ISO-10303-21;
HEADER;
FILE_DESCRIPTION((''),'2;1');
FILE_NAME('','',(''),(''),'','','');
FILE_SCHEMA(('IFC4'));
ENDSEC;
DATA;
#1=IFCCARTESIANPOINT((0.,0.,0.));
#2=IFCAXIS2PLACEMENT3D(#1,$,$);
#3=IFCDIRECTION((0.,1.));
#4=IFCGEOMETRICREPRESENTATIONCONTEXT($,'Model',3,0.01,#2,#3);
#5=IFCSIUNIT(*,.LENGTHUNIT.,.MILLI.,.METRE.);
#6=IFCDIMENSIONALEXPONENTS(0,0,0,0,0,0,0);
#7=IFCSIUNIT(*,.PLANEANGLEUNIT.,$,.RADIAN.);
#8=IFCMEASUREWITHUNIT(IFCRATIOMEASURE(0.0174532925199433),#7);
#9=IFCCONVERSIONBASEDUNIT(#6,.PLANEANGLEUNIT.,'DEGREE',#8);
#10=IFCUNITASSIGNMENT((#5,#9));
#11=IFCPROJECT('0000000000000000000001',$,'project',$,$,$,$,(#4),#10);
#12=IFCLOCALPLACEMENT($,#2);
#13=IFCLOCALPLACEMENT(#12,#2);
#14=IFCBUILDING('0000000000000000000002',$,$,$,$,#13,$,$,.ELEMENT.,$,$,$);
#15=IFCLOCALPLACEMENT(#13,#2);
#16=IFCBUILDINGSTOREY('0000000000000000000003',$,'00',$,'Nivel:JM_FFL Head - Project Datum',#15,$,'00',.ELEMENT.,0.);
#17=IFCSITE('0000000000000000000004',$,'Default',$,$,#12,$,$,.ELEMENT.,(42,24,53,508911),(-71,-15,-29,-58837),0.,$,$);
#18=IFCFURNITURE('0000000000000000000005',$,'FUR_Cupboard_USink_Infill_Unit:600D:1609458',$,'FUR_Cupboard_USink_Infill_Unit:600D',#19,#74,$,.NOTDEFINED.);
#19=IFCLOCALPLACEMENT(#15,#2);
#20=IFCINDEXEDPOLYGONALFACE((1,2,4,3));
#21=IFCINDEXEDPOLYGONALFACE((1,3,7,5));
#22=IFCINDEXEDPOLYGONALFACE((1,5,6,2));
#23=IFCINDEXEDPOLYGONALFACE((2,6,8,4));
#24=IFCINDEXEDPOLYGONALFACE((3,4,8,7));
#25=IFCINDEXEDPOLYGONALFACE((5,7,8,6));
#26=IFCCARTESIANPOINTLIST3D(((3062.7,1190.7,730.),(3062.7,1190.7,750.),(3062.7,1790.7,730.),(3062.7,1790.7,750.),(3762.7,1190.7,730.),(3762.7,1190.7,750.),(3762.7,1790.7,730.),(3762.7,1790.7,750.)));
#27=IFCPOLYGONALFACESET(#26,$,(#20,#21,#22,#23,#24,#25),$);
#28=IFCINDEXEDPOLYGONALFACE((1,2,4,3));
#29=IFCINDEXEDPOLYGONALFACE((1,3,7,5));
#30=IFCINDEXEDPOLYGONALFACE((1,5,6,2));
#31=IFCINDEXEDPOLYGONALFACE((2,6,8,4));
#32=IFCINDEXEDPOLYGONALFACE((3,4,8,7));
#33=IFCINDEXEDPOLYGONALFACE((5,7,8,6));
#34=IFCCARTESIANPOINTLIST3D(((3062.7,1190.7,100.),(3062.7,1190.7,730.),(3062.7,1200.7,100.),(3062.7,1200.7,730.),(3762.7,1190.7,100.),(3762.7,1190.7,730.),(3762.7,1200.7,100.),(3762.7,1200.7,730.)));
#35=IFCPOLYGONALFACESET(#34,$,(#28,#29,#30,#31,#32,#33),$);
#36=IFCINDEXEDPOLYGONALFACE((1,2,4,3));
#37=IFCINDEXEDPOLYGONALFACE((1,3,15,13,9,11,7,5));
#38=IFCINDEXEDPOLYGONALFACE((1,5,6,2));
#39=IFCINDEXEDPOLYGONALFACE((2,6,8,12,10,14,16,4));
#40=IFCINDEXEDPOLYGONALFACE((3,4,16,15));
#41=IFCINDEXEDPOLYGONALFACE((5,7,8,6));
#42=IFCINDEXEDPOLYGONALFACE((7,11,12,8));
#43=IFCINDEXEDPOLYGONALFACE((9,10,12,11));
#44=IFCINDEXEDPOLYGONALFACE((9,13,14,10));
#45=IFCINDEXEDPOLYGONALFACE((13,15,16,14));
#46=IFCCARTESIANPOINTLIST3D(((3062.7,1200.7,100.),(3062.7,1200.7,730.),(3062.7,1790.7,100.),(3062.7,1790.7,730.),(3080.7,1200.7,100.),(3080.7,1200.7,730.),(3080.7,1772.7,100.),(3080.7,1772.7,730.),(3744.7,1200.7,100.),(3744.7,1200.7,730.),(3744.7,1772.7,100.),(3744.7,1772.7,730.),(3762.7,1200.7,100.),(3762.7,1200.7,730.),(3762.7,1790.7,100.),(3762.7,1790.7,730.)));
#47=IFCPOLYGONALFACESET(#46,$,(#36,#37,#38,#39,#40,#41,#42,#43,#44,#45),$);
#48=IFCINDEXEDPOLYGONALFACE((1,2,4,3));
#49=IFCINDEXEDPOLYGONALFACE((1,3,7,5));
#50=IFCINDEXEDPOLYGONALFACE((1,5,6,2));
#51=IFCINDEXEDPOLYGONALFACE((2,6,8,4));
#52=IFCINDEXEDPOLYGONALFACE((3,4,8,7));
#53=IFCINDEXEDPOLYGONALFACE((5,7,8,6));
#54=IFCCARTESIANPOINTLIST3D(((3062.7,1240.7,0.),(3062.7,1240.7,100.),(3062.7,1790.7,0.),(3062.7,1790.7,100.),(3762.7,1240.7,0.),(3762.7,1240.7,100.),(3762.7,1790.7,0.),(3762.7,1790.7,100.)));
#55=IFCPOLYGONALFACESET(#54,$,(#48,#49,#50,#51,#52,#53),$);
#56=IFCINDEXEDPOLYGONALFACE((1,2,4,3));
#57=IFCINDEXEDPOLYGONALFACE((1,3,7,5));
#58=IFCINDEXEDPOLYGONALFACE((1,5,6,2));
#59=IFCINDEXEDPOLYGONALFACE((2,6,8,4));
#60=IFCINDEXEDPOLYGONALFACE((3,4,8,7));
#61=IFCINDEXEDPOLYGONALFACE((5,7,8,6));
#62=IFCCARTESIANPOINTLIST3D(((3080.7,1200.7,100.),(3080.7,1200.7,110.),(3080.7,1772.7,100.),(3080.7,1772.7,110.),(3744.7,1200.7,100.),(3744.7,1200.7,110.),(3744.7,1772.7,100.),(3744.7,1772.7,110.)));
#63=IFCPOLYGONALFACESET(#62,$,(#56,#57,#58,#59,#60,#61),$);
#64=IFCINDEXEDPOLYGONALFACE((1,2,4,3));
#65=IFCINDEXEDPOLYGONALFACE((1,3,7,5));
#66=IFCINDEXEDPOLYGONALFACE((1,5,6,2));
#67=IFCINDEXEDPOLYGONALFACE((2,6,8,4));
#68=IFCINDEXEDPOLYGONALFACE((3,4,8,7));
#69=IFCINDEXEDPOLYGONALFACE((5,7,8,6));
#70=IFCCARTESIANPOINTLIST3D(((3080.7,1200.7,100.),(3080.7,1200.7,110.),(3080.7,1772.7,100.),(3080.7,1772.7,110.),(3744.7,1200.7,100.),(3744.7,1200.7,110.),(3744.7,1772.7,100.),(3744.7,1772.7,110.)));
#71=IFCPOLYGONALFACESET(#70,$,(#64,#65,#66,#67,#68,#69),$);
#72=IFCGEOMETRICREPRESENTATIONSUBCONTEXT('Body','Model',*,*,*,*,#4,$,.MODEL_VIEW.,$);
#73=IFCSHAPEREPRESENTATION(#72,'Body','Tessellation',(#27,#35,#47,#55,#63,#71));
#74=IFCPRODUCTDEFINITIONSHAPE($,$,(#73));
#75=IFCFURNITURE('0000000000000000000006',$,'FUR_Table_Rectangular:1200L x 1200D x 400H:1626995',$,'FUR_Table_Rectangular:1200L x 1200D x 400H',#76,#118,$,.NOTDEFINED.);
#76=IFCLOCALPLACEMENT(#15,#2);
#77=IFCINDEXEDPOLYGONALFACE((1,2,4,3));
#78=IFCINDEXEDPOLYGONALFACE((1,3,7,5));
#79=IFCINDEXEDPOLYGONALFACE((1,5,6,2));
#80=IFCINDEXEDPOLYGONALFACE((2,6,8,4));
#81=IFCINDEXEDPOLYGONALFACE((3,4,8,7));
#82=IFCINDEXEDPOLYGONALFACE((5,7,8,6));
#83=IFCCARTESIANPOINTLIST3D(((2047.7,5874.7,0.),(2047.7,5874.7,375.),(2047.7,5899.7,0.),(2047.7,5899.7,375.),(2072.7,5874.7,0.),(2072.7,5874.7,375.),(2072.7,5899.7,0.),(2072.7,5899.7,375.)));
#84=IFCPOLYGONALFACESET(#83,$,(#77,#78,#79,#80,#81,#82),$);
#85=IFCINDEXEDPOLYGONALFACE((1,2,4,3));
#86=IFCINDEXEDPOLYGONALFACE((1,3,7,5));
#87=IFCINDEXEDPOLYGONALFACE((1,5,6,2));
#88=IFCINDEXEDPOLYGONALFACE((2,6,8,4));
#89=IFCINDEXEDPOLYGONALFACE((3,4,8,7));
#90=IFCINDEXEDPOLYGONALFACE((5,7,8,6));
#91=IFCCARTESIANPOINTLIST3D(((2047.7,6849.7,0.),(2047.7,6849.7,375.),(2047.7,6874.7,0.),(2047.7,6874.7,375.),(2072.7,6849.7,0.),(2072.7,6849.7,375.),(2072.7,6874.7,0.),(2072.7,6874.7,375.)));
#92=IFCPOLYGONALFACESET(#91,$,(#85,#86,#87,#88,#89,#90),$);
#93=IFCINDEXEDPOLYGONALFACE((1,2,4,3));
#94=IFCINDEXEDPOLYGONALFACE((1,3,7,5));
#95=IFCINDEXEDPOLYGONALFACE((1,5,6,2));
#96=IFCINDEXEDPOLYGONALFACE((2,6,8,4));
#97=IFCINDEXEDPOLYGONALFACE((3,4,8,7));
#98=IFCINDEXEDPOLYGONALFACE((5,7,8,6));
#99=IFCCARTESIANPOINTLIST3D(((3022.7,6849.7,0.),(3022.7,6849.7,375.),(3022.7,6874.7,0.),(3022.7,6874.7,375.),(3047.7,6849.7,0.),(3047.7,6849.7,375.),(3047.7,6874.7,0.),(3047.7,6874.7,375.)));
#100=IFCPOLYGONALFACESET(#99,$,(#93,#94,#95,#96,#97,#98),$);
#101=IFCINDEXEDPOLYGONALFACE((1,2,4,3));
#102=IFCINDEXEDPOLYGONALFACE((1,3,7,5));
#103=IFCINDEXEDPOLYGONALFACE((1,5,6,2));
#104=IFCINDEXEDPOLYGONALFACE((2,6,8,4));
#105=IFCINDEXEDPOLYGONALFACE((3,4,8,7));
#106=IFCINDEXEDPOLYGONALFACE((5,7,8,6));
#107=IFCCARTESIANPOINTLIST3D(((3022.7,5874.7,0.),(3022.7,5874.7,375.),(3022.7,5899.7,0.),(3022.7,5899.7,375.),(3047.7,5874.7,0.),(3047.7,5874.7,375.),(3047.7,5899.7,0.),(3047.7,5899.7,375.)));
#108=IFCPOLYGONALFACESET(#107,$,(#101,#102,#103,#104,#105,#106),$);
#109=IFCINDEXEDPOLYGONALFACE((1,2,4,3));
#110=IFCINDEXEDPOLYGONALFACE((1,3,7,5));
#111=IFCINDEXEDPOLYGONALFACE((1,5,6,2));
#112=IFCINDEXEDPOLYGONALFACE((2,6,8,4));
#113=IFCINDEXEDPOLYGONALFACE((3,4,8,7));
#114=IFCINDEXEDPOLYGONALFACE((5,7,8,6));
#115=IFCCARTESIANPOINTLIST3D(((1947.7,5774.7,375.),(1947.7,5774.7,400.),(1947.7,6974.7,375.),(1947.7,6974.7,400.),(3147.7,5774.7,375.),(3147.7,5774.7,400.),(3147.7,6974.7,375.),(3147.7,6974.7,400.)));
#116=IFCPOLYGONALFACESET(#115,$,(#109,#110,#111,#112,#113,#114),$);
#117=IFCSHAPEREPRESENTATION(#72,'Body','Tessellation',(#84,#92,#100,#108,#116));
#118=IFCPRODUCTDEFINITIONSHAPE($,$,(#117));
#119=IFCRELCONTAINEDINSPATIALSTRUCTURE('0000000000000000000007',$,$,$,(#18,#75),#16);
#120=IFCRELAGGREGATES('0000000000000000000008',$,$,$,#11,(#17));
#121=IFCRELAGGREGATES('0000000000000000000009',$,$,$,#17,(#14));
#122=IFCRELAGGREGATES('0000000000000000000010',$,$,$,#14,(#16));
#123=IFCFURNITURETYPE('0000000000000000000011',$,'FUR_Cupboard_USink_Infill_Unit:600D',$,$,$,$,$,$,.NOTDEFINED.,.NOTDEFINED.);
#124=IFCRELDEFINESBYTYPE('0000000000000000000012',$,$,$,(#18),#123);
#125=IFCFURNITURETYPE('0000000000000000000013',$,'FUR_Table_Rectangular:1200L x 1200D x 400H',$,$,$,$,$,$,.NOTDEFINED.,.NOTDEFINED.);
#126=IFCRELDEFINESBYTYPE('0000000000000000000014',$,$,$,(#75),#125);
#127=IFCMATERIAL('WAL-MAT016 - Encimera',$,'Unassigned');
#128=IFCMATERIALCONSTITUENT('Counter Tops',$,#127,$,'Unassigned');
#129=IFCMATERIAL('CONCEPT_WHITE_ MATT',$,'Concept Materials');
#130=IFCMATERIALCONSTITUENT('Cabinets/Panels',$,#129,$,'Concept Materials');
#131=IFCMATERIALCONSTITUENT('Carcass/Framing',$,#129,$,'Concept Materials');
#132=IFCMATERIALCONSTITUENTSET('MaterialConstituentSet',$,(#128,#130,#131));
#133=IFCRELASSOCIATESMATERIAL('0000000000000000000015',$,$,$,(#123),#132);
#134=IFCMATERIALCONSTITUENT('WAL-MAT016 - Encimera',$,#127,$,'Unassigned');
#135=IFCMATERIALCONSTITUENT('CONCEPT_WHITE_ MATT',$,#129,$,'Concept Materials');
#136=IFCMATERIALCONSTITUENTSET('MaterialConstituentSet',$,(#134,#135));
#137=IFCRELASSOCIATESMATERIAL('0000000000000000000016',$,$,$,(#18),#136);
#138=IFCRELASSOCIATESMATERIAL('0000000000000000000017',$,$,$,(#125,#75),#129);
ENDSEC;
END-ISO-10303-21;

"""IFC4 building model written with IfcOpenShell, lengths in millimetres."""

from ifc_helpers import new_model, entity, si_unit, converted_unit, direction, frame, origin, place, context, subcontext, project, spatial, indexed_curve, outline, extrude, source, transform, mapped, material, constituent, constituent_set, type_object, type_shapes, element, save


model = new_model("IFC4")

# Units and contexts
model_context = context("Model", 3, precision=0.01, world=origin(), true_north=direction((0.0, 1.0)))
body_context = subcontext(model_context, "Body", "Model", "MODEL_VIEW")
ifc_project = project(units=[si_unit("LENGTHUNIT", "METRE", prefix="MILLI"), converted_unit("PLANEANGLEUNIT", "DEGREE", entity("IfcRatioMeasure", 0.0174532925199433), si_unit("PLANEANGLEUNIT", "RADIAN"), dimensions=[0, 0, 0, 0, 0, 0, 0])], contexts=[model_context])

# Site, building, storey
site_placement = place(None, origin())
site = spatial("IfcSite", under=ifc_project, at=site_placement, Name="Default", CompositionType="ELEMENT", RefLatitude=(42, 24, 53, 508911), RefLongitude=(-71, -15, -29, -58837), RefElevation=0.0)
building_placement = place(site_placement, origin())
building = spatial("IfcBuilding", under=site, at=building_placement, CompositionType="ELEMENT")
storey_placement = place(building_placement, origin())
storey = spatial("IfcBuildingStorey", under=building, at=storey_placement, Name="00", ObjectType="Nivel:JM_FFL Head - Project Datum", LongName="00", CompositionType="ELEMENT", Elevation=0.0)

# Shared definitions
ifc_material_1 = material(Name="CONCEPT_WHITE_ MATT", Category="Concept Materials")

# Furniture
ifc_material_2 = material(Name="WAL-MAT016 - Encimera", Category="Unassigned")
ifc_constituent_1 = constituent(ifc_material_2, Name="WAL-MAT016 - Encimera", Category="Unassigned")
ifc_constituent_2 = constituent(ifc_material_1, Name="CONCEPT_WHITE_ MATT", Category="Concept Materials")
ifc_constituent_set_1 = constituent_set(constituents=[ifc_constituent_1, ifc_constituent_2], Name="MaterialConstituentSet")
ifc_constituent_3 = constituent(ifc_material_2, Name="Counter Tops", Category="Unassigned")
ifc_constituent_4 = constituent(ifc_material_1, Name="Cabinets/Panels", Category="Concept Materials")
ifc_constituent_5 = constituent(ifc_material_1, Name="Carcass/Framing", Category="Concept Materials")
ifc_constituent_set_2 = constituent_set(constituents=[ifc_constituent_3, ifc_constituent_4, ifc_constituent_5], Name="MaterialConstituentSet")
furniture_type_1 = type_object("IfcFurnitureType", Name="FUR_Cupboard_USink_Infill_Unit:600D", AssemblyPlace="NOTDEFINED", PredefinedType="NOTDEFINED", material=ifc_constituent_set_2)
shared_shape_1 = source(origin(), body_context, "Body", "SweptSolid", [
    extrude(outline(indexed_curve([(-300.0, -350.0), (300.0, -350.0), (300.0, 350.0), (-300.0, 350.0), (-300.0, -350.0)], self_intersect=False)), frame((44.7, 300.0, 730.0), z_axis=(0.0, 0.0, 1.0), x_axis=(0.0, 1.0, 0.0)), (0.0, 0.0, 1.0), 20.0),
    extrude(outline(indexed_curve([(-5.0, -350.0), (5.0, -350.0), (5.0, 350.0), (-5.0, 350.0), (-5.0, -350.0)], self_intersect=False)), frame((44.7, 595.0, 100.0), z_axis=(0.0, 0.0, 1.0), x_axis=(0.0, 1.0, 0.0)), (0.0, 0.0, 1.0), 630.0),
    extrude(outline(indexed_curve([(-299.5, -350.0), (290.5, -350.0), (290.5, -332.0), (-281.5, -332.0), (-281.5, 332.0), (290.5, 332.0), (290.5, 350.0), (-299.5, 350.0), (-299.5, -350.0)], self_intersect=False)), frame((44.7, 299.5, 100.0), z_axis=(0.0, 0.0, 1.0), x_axis=(0.0, 1.0, 0.0)), (0.0, 0.0, 1.0), 630.0),
    extrude(outline(indexed_curve([(-275.0, -350.0), (275.0, -350.0), (275.0, 350.0), (-275.0, 350.0), (-275.0, -350.0)], self_intersect=False)), frame((44.7, 275.0, 0.0), z_axis=(0.0, 0.0, 1.0), x_axis=(0.0, 1.0, 0.0)), (0.0, 0.0, 1.0), 100.0),
    extrude(outline(indexed_curve([(-286.0, -332.0), (286.0, -332.0), (286.0, 332.0), (-286.0, 332.0), (-286.0, -332.0)], self_intersect=False)), frame((44.7, 304.0, 100.0), z_axis=(0.0, 0.0, 1.0), x_axis=(0.0, 1.0, 0.0)), (0.0, 0.0, 1.0), 10.0),
    extrude(outline(indexed_curve([(-286.0, -332.0), (286.0, -332.0), (286.0, 332.0), (-286.0, 332.0), (-286.0, -332.0)], self_intersect=False)), frame((44.7, 304.0, 100.0), z_axis=(0.0, 0.0, 1.0), x_axis=(0.0, 1.0, 0.0)), (0.0, 0.0, 1.0), 10.0),
])
type_shapes(furniture_type_1, [shared_shape_1])
furniture_1_placement = place(storey_placement, frame((3457.4, 1790.7, 0.0), z_axis=(0.0, 0.0, 1.0), x_axis=(-1.0, 0.0, 0.0)))
element("IfcFurniture", 1, at=furniture_1_placement, inside=storey, type_object=furniture_type_1, material=ifc_constituent_set_1, Name="FUR_Cupboard_USink_Infill_Unit:600D:1609458", ObjectType="FUR_Cupboard_USink_Infill_Unit:600D", PredefinedType="NOTDEFINED", context=body_context, shape_type="MappedRepresentation", body=[
    mapped(shared_shape_1, transform((0.0, 0.0, 0.0), scale=1.0)),
])
furniture_type_2 = type_object("IfcFurnitureType", Name="FUR_Table_Rectangular:1200L x 1200D x 400H", AssemblyPlace="NOTDEFINED", PredefinedType="NOTDEFINED", material=ifc_material_1)
shared_shape_2 = source(origin(), body_context, "Body", "SweptSolid", [
    extrude(outline(indexed_curve([(-12.5, -12.5), (12.5, -12.5), (12.5, 12.5), (-12.5, 12.5), (-12.5, -12.5)], self_intersect=False)), frame((87.5, -687.5, 0.0), z_axis=(0.0, 0.0, 1.0), x_axis=(0.0, 1.0, 0.0)), (0.0, 0.0, 1.0), 375.0),
    extrude(outline(indexed_curve([(-12.5, -12.5), (12.5, -12.5), (12.5, 12.5), (-12.5, 12.5), (-12.5, -12.5)], self_intersect=False)), frame((-887.5, -687.5, 0.0), z_axis=(0.0, 0.0, 1.0), x_axis=(0.0, 1.0, 0.0)), (0.0, 0.0, 1.0), 375.0),
    extrude(outline(indexed_curve([(-12.5, -12.5), (12.5, -12.5), (12.5, 12.5), (-12.5, 12.5), (-12.5, -12.5)], self_intersect=False)), frame((-887.5, 287.5, 0.0), z_axis=(0.0, 0.0, 1.0), x_axis=(0.0, 1.0, 0.0)), (0.0, 0.0, 1.0), 375.0),
    extrude(outline(indexed_curve([(-12.5, -12.5), (12.5, -12.5), (12.5, 12.5), (-12.5, 12.5), (-12.5, -12.5)], self_intersect=False)), frame((87.5, 287.5, 0.0), z_axis=(0.0, 0.0, 1.0), x_axis=(0.0, 1.0, 0.0)), (0.0, 0.0, 1.0), 375.0),
    extrude(outline(indexed_curve([(-600.0, -600.0), (600.0, -600.0), (600.0, 600.0), (-600.0, 600.0), (-600.0, -600.0)], self_intersect=False)), frame((-400.0, -200.0, 375.0), z_axis=(0.0, 0.0, 1.0), x_axis=(0.0, 1.0, 0.0)), (0.0, 0.0, 1.0), 25.0),
])
type_shapes(furniture_type_2, [shared_shape_2])
furniture_2_placement = place(storey_placement, frame((2747.7, 5974.7, 0.0), z_axis=(0.0, 0.0, 1.0), x_axis=(0.0, -1.0, 0.0)))
element("IfcFurniture", 2, at=furniture_2_placement, inside=storey, type_object=furniture_type_2, material=ifc_material_1, Name="FUR_Table_Rectangular:1200L x 1200D x 400H:1626995", ObjectType="FUR_Table_Rectangular:1200L x 1200D x 400H", PredefinedType="NOTDEFINED", context=body_context, shape_type="MappedRepresentation", body=[
    mapped(shared_shape_2, transform((0.0, 0.0, 0.0), scale=1.0)),
])

save(model, "model.ifc")
